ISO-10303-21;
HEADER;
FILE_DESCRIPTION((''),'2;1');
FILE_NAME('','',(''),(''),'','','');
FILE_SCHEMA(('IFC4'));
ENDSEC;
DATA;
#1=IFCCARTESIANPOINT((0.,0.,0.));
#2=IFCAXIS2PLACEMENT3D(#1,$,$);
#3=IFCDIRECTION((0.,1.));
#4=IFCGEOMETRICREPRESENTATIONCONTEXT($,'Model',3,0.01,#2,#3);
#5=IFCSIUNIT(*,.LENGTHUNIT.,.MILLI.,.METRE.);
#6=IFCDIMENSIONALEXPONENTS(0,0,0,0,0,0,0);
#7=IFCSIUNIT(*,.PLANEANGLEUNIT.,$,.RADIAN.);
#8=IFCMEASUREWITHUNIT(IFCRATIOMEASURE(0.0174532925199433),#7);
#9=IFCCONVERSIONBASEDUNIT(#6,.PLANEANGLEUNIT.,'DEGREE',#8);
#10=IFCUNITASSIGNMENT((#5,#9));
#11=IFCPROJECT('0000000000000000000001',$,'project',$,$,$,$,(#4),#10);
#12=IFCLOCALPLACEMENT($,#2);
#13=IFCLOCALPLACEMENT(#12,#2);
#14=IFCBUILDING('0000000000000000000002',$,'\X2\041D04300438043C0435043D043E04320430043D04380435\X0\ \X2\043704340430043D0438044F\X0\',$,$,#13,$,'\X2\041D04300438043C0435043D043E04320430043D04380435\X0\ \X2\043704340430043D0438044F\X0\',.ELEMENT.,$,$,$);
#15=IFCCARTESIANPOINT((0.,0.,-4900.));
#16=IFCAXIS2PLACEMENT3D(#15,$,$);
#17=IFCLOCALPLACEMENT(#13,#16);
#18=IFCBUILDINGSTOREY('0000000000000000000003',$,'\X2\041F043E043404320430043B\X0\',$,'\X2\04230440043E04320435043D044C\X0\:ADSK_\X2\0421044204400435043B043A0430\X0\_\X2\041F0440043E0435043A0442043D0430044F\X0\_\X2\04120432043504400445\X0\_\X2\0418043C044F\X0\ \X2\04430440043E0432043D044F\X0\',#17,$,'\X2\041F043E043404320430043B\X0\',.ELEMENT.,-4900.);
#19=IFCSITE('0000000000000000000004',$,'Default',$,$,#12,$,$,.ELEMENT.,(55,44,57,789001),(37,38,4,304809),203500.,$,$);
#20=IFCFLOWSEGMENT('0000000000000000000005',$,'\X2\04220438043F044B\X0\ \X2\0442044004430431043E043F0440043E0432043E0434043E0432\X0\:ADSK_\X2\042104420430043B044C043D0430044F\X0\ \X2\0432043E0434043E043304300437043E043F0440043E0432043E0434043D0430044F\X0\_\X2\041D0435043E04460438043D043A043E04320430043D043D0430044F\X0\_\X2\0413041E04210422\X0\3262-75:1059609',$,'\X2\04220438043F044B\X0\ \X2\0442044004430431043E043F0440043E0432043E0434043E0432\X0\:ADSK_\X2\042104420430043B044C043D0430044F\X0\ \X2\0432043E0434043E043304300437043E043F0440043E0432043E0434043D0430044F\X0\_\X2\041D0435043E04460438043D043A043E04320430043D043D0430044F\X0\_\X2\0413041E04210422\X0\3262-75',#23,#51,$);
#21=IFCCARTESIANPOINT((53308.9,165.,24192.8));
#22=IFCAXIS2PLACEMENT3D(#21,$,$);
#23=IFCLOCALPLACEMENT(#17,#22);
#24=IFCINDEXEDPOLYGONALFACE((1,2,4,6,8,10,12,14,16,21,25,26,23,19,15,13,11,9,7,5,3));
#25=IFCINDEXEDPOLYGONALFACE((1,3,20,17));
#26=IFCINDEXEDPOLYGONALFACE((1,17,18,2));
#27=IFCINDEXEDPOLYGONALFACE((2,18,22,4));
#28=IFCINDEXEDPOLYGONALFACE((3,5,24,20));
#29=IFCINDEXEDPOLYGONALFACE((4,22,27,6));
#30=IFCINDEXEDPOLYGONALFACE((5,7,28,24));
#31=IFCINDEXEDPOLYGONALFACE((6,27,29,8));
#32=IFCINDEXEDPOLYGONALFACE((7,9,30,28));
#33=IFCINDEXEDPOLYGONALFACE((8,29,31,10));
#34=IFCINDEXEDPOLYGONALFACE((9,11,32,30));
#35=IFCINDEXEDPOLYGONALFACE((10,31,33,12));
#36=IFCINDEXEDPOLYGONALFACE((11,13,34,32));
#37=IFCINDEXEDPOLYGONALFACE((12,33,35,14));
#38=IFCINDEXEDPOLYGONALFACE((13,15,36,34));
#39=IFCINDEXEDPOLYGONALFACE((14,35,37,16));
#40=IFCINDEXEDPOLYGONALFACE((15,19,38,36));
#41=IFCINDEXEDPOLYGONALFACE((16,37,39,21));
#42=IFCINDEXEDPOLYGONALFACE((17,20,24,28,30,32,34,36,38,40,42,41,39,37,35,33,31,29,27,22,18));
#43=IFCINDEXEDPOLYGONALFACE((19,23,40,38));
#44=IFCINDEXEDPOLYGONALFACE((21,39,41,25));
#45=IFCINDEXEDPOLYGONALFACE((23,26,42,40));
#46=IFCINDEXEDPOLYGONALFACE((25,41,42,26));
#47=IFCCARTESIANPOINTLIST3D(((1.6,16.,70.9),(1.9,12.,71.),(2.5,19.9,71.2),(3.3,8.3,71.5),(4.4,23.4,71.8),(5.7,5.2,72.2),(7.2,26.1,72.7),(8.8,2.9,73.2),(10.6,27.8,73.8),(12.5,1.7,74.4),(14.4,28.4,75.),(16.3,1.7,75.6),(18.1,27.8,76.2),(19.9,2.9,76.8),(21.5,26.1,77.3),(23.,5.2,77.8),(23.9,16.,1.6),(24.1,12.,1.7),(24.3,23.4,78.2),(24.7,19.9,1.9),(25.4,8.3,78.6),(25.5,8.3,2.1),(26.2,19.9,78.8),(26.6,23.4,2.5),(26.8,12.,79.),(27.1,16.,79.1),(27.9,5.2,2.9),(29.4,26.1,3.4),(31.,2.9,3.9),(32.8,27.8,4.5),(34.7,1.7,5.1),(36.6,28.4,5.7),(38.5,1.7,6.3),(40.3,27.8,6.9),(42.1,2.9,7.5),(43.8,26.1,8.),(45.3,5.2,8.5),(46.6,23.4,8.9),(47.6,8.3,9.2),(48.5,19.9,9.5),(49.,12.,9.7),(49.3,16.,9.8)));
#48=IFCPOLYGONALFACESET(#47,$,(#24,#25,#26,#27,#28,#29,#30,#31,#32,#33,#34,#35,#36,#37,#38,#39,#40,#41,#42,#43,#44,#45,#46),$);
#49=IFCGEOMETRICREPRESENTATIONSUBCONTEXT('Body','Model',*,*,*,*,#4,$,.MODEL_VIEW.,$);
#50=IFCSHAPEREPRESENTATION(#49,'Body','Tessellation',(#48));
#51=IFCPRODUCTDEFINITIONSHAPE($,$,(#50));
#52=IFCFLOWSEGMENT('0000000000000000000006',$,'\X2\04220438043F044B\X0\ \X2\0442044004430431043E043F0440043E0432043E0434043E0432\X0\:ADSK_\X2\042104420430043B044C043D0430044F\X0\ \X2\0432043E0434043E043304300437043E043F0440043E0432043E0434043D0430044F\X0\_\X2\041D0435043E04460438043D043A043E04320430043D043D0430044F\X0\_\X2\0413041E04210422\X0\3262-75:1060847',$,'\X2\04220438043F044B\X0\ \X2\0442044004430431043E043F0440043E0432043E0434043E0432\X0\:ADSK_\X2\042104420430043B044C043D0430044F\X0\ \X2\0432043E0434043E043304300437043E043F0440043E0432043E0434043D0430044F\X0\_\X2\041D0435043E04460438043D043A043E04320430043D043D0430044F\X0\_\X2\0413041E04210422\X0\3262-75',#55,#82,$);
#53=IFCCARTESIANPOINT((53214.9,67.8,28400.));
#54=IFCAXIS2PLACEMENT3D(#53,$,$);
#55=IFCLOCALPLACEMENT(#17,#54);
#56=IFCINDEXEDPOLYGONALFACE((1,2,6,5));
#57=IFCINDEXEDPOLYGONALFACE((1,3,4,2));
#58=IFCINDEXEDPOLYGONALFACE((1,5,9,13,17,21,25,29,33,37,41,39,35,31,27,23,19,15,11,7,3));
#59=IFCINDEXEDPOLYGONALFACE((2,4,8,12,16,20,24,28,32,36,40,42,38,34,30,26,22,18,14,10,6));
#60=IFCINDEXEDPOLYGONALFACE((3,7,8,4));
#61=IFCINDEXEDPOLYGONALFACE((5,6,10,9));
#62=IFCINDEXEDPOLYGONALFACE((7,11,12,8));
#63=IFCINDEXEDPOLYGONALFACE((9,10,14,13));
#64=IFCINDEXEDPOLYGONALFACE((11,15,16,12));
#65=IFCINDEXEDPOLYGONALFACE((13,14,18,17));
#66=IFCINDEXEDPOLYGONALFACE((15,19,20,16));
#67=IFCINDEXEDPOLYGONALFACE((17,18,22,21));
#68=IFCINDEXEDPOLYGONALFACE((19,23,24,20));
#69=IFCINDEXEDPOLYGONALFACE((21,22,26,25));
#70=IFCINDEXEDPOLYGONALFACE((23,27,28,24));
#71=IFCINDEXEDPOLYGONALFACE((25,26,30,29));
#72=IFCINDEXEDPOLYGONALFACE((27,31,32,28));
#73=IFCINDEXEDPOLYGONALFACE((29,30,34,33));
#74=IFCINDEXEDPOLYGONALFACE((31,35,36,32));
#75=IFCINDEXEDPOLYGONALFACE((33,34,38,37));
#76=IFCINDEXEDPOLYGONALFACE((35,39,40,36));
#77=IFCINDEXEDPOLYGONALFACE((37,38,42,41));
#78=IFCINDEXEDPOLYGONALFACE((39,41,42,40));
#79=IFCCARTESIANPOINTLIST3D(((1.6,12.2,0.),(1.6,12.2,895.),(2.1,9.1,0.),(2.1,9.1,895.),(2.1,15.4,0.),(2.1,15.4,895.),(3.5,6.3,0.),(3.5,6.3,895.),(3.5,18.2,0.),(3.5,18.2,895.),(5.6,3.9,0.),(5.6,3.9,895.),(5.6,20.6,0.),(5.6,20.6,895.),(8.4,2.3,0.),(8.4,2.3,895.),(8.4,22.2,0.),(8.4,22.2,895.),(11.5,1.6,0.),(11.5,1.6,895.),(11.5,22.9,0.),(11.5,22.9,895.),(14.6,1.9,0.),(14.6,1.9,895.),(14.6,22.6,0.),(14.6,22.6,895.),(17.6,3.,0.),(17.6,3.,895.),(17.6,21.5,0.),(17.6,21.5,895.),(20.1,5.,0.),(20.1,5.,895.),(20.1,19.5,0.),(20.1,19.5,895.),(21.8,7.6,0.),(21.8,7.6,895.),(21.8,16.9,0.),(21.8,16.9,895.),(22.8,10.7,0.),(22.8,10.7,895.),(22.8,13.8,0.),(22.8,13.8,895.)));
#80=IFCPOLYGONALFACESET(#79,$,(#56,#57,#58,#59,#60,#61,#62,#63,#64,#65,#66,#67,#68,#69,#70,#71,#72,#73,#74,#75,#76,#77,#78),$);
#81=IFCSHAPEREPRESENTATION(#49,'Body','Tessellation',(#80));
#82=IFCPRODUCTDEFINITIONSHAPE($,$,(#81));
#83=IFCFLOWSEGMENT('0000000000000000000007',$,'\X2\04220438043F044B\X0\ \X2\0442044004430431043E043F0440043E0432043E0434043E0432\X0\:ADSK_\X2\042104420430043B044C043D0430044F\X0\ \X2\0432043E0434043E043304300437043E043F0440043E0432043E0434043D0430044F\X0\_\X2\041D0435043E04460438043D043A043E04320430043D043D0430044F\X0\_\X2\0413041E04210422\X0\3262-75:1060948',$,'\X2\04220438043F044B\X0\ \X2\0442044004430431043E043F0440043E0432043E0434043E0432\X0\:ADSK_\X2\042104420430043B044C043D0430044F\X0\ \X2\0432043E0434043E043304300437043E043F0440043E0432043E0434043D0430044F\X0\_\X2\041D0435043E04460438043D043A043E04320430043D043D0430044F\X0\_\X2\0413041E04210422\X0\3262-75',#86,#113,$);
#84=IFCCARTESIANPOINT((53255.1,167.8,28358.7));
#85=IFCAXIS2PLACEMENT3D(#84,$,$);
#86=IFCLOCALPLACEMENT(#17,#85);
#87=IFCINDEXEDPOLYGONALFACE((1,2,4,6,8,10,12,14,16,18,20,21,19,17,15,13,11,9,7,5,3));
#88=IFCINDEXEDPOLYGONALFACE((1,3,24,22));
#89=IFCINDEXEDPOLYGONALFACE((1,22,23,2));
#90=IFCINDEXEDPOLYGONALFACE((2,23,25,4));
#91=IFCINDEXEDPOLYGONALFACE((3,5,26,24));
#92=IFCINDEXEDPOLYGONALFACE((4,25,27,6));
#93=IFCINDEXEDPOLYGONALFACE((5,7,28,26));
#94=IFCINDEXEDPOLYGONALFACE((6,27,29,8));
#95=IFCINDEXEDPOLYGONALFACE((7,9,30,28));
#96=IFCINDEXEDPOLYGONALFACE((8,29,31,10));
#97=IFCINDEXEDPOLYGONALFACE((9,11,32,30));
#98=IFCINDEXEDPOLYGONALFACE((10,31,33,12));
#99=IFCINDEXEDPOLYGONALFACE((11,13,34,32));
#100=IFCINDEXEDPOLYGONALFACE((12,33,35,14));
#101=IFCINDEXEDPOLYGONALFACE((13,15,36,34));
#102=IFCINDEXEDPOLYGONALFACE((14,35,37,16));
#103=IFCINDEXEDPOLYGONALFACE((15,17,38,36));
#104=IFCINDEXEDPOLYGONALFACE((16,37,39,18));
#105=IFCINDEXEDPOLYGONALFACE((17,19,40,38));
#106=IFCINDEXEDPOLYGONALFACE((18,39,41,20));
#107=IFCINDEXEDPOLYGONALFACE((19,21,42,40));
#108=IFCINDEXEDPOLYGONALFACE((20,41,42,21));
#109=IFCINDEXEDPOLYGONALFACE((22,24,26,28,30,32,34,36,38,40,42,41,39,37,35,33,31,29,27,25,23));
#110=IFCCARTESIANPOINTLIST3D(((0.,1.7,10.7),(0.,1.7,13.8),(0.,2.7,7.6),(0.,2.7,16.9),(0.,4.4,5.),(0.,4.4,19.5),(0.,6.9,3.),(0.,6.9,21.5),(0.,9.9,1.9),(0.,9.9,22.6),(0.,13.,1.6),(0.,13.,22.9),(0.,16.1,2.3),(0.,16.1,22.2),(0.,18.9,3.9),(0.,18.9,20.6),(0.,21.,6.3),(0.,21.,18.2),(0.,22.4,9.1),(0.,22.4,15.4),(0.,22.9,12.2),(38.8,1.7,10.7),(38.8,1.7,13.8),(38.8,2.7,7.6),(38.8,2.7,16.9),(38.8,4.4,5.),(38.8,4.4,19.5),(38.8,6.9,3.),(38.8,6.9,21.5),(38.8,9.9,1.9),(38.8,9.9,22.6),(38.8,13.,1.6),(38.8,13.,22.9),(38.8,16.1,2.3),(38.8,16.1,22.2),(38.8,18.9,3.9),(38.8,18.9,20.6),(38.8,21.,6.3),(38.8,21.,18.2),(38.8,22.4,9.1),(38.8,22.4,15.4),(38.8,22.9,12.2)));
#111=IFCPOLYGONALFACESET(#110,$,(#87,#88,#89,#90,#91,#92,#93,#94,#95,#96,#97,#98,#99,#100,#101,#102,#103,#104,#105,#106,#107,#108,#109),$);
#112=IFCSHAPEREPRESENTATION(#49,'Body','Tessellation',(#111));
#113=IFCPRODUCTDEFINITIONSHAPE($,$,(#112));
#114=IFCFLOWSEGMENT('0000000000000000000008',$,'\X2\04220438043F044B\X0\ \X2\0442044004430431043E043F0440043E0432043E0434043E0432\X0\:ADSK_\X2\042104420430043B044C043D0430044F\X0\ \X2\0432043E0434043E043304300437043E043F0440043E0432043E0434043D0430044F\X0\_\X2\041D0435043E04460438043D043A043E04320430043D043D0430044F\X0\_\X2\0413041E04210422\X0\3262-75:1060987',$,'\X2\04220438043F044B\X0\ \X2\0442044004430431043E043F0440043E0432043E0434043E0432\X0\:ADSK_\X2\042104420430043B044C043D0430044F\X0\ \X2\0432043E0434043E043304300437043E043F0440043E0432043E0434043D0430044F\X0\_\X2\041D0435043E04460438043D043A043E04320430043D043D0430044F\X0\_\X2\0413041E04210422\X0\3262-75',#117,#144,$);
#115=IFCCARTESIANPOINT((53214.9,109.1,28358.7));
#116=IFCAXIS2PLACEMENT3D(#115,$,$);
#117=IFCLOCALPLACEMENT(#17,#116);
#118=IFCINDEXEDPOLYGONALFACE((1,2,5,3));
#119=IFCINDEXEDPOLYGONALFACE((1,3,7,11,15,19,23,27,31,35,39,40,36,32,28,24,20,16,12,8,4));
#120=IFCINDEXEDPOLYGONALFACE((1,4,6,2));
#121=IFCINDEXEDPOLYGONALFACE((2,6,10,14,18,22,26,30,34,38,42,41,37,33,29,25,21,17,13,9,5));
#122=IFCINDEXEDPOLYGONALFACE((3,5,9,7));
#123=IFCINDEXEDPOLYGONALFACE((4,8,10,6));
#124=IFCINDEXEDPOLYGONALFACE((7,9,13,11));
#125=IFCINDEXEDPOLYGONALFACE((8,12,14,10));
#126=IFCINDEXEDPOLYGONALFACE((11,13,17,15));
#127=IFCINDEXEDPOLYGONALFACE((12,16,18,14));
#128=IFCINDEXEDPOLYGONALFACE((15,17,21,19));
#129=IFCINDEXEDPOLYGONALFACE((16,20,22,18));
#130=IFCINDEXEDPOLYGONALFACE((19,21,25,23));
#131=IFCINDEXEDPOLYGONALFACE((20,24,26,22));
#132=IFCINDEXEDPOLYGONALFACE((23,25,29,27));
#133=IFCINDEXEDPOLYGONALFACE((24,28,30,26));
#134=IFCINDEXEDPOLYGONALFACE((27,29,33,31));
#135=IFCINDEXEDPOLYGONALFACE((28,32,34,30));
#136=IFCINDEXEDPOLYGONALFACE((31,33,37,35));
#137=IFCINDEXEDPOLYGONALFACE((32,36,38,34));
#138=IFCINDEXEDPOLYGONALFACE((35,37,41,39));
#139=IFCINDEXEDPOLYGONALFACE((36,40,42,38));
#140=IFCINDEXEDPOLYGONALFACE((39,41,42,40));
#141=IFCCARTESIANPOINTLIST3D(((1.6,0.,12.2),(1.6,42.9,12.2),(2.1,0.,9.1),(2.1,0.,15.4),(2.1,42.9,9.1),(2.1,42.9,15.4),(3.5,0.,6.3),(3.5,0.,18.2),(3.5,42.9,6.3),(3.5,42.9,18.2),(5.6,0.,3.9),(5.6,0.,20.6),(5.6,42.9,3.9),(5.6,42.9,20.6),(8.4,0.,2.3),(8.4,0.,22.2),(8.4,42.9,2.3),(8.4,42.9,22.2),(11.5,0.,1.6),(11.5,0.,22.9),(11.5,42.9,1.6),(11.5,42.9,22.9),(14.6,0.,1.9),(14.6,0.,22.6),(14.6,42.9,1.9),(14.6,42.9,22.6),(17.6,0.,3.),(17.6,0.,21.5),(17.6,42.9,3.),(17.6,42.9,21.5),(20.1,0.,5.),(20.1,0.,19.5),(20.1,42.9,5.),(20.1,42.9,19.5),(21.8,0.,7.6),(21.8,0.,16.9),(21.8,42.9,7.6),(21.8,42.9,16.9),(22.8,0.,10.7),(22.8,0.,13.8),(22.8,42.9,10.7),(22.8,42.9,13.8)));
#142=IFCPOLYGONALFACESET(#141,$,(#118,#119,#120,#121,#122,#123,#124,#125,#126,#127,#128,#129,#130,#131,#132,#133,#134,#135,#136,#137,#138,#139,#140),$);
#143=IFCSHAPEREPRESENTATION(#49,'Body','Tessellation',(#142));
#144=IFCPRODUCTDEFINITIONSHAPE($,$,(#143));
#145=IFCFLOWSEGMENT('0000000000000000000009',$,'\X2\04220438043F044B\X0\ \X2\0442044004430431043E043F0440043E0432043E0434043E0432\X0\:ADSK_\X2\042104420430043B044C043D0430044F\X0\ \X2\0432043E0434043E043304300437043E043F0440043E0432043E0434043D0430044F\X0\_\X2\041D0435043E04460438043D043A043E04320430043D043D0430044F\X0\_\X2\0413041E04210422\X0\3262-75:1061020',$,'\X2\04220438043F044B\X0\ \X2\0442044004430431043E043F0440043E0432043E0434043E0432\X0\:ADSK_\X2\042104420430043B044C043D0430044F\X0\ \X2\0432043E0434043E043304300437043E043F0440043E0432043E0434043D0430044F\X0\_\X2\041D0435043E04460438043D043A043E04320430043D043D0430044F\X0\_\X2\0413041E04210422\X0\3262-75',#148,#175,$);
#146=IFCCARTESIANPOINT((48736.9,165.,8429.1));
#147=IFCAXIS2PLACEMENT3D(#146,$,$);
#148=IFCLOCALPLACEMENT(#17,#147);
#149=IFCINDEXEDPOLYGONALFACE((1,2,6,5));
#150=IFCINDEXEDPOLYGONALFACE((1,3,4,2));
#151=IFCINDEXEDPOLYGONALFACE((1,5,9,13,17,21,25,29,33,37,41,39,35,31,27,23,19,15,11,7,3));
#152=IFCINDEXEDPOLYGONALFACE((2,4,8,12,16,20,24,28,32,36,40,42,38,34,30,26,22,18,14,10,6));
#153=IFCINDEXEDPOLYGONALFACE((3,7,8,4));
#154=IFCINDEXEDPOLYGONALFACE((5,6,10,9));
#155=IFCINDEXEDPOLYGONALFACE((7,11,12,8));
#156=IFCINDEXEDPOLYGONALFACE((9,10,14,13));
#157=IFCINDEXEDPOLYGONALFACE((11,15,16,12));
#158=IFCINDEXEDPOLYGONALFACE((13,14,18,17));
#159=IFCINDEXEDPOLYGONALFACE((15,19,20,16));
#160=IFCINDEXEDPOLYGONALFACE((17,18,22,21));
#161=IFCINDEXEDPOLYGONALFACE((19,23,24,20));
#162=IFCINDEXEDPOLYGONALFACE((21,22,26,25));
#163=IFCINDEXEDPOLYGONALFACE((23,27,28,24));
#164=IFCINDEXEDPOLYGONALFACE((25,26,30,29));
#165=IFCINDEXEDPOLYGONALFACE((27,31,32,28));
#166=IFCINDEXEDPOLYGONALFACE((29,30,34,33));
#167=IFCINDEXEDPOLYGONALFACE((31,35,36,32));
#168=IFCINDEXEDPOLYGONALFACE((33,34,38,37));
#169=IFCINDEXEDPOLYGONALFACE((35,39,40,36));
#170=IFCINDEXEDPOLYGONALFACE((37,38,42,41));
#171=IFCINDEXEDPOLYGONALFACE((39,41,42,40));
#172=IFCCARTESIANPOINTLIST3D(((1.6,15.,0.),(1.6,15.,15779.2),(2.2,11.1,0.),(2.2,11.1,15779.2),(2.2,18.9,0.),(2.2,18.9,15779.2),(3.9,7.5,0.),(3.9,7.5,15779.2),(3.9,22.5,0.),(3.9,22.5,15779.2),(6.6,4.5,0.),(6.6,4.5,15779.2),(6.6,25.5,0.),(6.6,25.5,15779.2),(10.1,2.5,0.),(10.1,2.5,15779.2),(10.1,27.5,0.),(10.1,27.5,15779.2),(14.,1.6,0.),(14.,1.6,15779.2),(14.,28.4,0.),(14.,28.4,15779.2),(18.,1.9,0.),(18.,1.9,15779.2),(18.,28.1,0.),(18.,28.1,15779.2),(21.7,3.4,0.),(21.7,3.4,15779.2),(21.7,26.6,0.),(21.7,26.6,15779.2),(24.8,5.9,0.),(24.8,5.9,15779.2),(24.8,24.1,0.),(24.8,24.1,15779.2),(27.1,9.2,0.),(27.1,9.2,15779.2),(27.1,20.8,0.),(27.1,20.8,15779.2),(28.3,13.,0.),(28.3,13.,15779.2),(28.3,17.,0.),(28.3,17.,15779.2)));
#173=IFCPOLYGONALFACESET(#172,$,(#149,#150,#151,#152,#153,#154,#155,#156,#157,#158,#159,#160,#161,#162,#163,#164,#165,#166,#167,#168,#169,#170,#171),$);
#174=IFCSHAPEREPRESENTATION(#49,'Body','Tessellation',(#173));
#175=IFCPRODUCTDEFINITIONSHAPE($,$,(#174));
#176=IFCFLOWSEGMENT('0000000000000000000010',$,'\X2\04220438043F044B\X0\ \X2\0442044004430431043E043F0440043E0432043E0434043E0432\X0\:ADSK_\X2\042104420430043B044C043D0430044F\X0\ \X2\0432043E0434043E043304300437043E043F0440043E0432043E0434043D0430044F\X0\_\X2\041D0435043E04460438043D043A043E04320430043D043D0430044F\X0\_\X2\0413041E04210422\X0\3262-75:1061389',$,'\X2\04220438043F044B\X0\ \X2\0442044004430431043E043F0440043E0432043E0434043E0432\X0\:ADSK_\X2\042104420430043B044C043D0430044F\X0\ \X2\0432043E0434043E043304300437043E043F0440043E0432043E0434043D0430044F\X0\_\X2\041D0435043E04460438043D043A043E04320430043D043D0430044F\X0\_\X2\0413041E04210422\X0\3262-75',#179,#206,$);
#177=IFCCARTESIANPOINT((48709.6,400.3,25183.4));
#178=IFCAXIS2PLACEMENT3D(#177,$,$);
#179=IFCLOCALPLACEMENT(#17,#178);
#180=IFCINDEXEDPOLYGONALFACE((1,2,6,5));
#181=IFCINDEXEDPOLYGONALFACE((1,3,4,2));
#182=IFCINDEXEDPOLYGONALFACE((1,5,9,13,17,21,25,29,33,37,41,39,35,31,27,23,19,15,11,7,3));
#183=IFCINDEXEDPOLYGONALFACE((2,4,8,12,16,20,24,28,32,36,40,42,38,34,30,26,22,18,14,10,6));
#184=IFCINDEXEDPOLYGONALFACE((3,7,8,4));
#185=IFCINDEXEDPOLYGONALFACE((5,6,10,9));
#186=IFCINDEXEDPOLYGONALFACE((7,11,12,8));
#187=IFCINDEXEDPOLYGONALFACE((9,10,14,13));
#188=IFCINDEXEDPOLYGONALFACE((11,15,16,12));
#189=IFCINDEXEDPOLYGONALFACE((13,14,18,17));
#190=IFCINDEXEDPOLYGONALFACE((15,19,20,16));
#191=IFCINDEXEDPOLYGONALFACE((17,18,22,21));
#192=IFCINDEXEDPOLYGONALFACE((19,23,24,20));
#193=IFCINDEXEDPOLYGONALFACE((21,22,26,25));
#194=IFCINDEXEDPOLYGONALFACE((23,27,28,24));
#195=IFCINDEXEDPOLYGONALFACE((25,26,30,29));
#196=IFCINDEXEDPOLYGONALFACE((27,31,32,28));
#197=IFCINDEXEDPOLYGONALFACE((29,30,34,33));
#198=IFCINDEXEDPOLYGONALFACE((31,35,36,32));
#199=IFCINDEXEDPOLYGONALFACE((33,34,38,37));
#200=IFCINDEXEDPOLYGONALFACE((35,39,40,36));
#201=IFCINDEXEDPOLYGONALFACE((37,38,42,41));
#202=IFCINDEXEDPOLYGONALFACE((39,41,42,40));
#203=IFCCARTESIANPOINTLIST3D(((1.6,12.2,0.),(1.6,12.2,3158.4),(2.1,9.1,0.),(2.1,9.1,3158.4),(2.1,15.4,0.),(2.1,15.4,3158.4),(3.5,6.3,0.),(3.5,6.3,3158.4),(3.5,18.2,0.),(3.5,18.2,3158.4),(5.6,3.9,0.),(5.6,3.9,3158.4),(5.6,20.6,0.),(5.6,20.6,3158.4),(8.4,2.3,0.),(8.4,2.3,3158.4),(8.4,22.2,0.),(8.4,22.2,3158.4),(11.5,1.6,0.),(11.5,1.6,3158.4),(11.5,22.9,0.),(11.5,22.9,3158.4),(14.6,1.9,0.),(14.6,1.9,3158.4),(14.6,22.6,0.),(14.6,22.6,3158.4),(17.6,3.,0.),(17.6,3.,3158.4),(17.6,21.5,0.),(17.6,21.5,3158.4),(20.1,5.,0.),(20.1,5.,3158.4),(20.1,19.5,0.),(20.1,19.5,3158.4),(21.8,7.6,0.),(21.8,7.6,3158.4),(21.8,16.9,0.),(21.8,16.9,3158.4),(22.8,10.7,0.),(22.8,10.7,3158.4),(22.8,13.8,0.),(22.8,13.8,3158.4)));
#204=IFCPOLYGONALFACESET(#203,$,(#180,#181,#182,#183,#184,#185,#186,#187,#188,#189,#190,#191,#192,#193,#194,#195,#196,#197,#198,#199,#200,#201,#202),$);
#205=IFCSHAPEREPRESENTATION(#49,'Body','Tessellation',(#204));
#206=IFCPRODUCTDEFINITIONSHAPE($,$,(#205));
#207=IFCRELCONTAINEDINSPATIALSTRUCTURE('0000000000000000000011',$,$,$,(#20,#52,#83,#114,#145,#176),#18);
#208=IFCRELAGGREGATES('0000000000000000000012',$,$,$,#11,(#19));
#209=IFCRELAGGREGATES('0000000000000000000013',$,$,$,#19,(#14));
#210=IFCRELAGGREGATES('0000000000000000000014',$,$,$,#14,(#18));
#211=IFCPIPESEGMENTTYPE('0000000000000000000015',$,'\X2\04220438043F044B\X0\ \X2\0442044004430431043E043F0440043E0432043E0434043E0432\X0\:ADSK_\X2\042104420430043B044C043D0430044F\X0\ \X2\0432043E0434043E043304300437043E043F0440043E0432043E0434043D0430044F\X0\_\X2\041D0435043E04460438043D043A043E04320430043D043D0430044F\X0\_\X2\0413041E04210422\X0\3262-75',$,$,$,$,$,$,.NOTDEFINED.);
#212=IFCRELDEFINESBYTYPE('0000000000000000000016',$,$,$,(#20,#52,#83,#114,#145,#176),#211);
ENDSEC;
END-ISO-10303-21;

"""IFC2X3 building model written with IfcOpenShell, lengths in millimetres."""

from ifc_helpers import new_model, entity, si_unit, converted_unit, direction, frame, origin, origin_2d_with_axis, place, context, subcontext, project, spatial, circle, extrude, type_object, element, save


model = new_model("IFC2X3")

# Units and contexts
model_context = context("Model", 3, precision=0.01, world=origin(), true_north=direction((0.0, 1.0)))
body_context = subcontext(model_context, "Body", "Model", "MODEL_VIEW")
ifc_project = project(units=[si_unit("LENGTHUNIT", "METRE", prefix="MILLI"), converted_unit("PLANEANGLEUNIT", "DEGREE", entity("IfcRatioMeasure", 0.0174532925199433), si_unit("PLANEANGLEUNIT", "RADIAN"), dimensions=[0, 0, 0, 0, 0, 0, 0])], contexts=[model_context])

# Site, building, storey
site_placement = place(None, origin())
site = spatial("IfcSite", under=ifc_project, at=site_placement, Name="Default", CompositionType="ELEMENT", RefLatitude=(55, 44, 57, 789001), RefLongitude=(37, 38, 4, 304809), RefElevation=203500.0)
building_placement = place(site_placement, origin())
building = spatial("IfcBuilding", under=site, at=building_placement, Name="Наименование здания", LongName="Наименование здания", CompositionType="ELEMENT")
storey_placement = place(building_placement, frame((0.0, 0.0, -4900.0)))
storey = spatial("IfcBuildingStorey", under=building, at=storey_placement, Name="Подвал", ObjectType="Уровень:ADSK_Стрелка_Проектная_Вверх_Имя уровня", LongName="Подвал", CompositionType="ELEMENT", Elevation=-4900.0)

# Flow segments
pipe_segment_type = type_object("IfcPipeSegmentType", Name="Типы трубопроводов:ADSK_Стальная водогазопроводная_Неоцинкованная_ГОСТ3262-75", PredefinedType="NOTDEFINED")
flow_segment_1_placement = place(storey_placement, frame((53308.9, 165.0, 24192.8)))
element("IfcFlowSegment", 1, at=flow_segment_1_placement, inside=storey, type_object=pipe_segment_type, Name="Типы трубопроводов:ADSK_Стальная водогазопроводная_Неоцинкованная_ГОСТ3262-75:1059609", ObjectType="Типы трубопроводов:ADSK_Стальная водогазопроводная_Неоцинкованная_ГОСТ3262-75", context=body_context, shape_type="SweptSolid", body=[
    extrude(circle(Radius=13.4, at=origin_2d_with_axis()), frame((14.4, 15.0, 75.0), z_axis=(0.305222, 0.0, -0.952281), x_axis=(0.0, 1.0, 0.0)), (0.0, 0.0, 1.0), 72.8),
])
flow_segment_2_placement = place(storey_placement, frame((53214.9, 67.8, 28400.0)))
element("IfcFlowSegment", 2, at=flow_segment_2_placement, inside=storey, type_object=pipe_segment_type, Name="Типы трубопроводов:ADSK_Стальная водогазопроводная_Неоцинкованная_ГОСТ3262-75:1060847", ObjectType="Типы трубопроводов:ADSK_Стальная водогазопроводная_Неоцинкованная_ГОСТ3262-75", context=body_context, shape_type="SweptSolid", body=[
    extrude(circle(Radius=10.7, at=origin_2d_with_axis()), frame((12.2, 12.2, 0.0), z_axis=(0.0, 0.0, 1.0), x_axis=(-1.0, 0.0, 0.0)), (0.0, 0.0, 1.0), 895.0),
])
flow_segment_3_placement = place(storey_placement, frame((53255.1, 167.8, 28358.7)))
element("IfcFlowSegment", 3, at=flow_segment_3_placement, inside=storey, type_object=pipe_segment_type, Name="Типы трубопроводов:ADSK_Стальная водогазопроводная_Неоцинкованная_ГОСТ3262-75:1060948", ObjectType="Типы трубопроводов:ADSK_Стальная водогазопроводная_Неоцинкованная_ГОСТ3262-75", context=body_context, shape_type="SweptSolid", body=[
    extrude(circle(Radius=10.7, at=origin_2d_with_axis()), frame((0.0, 12.2, 12.2), z_axis=(1.0, 0.0, 0.0), x_axis=(0.0, 1.0, 0.0)), (0.0, 0.0, 1.0), 38.8),
])
flow_segment_4_placement = place(storey_placement, frame((53214.9, 109.1, 28358.7)))
element("IfcFlowSegment", 4, at=flow_segment_4_placement, inside=storey, type_object=pipe_segment_type, Name="Типы трубопроводов:ADSK_Стальная водогазопроводная_Неоцинкованная_ГОСТ3262-75:1060987", ObjectType="Типы трубопроводов:ADSK_Стальная водогазопроводная_Неоцинкованная_ГОСТ3262-75", context=body_context, shape_type="SweptSolid", body=[
    extrude(circle(Radius=10.7, at=origin_2d_with_axis()), frame((12.2, 0.0, 12.2), z_axis=(0.0, 1.0, 0.0), x_axis=(-1.0, 0.0, 0.0)), (0.0, 0.0, 1.0), 42.9),
])
flow_segment_5_placement = place(storey_placement, frame((48736.9, 165.0, 8429.1)))
element("IfcFlowSegment", 5, at=flow_segment_5_placement, inside=storey, type_object=pipe_segment_type, Name="Типы трубопроводов:ADSK_Стальная водогазопроводная_Неоцинкованная_ГОСТ3262-75:1061020", ObjectType="Типы трубопроводов:ADSK_Стальная водогазопроводная_Неоцинкованная_ГОСТ3262-75", context=body_context, shape_type="SweptSolid", body=[
    extrude(circle(Radius=13.4, at=origin_2d_with_axis()), frame((15.0, 15.0, 0.0), z_axis=(0.0, 0.0, 1.0), x_axis=(-1.0, 0.0, 0.0)), (0.0, 0.0, 1.0), 15779.2),
])
flow_segment_6_placement = place(storey_placement, frame((48709.6, 400.3, 25183.4)))
element("IfcFlowSegment", 6, at=flow_segment_6_placement, inside=storey, type_object=pipe_segment_type, Name="Типы трубопроводов:ADSK_Стальная водогазопроводная_Неоцинкованная_ГОСТ3262-75:1061389", ObjectType="Типы трубопроводов:ADSK_Стальная водогазопроводная_Неоцинкованная_ГОСТ3262-75", context=body_context, shape_type="SweptSolid", body=[
    extrude(circle(Radius=10.7, at=origin_2d_with_axis()), frame((12.2, 12.2, 0.0), z_axis=(0.0, 0.0, 1.0), x_axis=(-1.0, 0.0, 0.0)), (0.0, 0.0, 1.0), 3158.4),
])

save(model, "model.ifc")
